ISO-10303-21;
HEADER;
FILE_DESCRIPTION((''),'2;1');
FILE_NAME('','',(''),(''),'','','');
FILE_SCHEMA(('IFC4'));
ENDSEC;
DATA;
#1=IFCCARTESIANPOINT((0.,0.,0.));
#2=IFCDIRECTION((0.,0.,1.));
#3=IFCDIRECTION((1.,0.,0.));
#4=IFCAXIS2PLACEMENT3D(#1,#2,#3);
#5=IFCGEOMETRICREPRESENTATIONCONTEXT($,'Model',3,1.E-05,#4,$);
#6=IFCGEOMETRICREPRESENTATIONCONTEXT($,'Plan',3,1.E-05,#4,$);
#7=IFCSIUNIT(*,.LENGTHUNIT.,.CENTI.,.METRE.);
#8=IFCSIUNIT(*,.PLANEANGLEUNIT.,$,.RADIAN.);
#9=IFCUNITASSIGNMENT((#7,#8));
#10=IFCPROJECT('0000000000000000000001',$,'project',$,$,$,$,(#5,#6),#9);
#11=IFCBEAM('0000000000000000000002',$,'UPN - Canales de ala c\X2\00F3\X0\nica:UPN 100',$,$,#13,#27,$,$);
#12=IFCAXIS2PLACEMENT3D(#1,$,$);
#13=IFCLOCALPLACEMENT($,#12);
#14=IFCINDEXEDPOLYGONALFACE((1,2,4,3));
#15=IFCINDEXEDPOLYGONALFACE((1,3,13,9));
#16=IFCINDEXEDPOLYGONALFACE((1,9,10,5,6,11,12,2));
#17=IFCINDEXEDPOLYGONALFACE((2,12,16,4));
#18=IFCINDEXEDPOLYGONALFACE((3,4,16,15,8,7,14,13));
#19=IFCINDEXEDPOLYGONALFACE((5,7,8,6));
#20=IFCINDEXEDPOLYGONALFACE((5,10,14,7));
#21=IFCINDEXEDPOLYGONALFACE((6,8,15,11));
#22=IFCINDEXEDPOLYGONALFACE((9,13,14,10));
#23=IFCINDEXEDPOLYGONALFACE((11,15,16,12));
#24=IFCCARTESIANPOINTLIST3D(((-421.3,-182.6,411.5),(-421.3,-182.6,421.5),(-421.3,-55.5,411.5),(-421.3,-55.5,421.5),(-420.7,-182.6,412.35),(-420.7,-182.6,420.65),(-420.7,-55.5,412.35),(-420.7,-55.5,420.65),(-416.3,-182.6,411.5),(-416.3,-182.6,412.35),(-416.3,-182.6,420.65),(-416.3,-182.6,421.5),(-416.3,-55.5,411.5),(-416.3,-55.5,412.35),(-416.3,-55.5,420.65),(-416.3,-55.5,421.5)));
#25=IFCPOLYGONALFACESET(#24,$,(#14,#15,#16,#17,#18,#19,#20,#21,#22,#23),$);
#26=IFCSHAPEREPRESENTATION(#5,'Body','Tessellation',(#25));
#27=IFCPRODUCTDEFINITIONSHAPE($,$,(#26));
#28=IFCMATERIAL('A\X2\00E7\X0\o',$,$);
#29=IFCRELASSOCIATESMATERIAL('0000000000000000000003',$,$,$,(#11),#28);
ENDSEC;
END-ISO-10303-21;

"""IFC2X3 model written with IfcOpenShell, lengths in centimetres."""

from ifc_helpers import new_model, si_unit, frame, origin_with_axes, origin_2d_with_axis, place, context, project, u_section, extrude, material, element, save


model = new_model("IFC2X3")

# Units and contexts
model_context = context("Model", 3, precision=1e-05, world=origin_with_axes())
plan_context = context("Plan", 3, precision=1e-05, world=origin_with_axes())
ifc_project = project(units=[si_unit("LENGTHUNIT", "METRE", prefix="CENTI"), si_unit("PLANEANGLEUNIT", "RADIAN")], contexts=[model_context, plan_context])

# Shared definitions
ifc_material = material(Name="Aço")

# Beam
for number, where, z_axis, x_axis, name in (
    (1, (-418.8, -182.6, 416.5), (0.0, 1.0, 0.0), (1.0, 0.0, 0.0), "UPN - Canales de ala cónica:UPN 100"),
):
    element("IfcBeam", number, at=place(None, frame(where, z_axis=z_axis, x_axis=x_axis)), material=ifc_material, Name=name, context=model_context, shape_type="SweptSolid", body=[
        extrude(u_section(Depth=10.0, FlangeWidth=5.0, WebThickness=0.6, FlangeThickness=0.85, FilletRadius=0.0, EdgeRadius=0.0, FlangeSlope=0.0, CentreOfGravityInX=0.0, at=origin_2d_with_axis()), origin_with_axes(), (0.0, 0.0, 1.0), 127.1),
    ])

save(model, "model.ifc")
